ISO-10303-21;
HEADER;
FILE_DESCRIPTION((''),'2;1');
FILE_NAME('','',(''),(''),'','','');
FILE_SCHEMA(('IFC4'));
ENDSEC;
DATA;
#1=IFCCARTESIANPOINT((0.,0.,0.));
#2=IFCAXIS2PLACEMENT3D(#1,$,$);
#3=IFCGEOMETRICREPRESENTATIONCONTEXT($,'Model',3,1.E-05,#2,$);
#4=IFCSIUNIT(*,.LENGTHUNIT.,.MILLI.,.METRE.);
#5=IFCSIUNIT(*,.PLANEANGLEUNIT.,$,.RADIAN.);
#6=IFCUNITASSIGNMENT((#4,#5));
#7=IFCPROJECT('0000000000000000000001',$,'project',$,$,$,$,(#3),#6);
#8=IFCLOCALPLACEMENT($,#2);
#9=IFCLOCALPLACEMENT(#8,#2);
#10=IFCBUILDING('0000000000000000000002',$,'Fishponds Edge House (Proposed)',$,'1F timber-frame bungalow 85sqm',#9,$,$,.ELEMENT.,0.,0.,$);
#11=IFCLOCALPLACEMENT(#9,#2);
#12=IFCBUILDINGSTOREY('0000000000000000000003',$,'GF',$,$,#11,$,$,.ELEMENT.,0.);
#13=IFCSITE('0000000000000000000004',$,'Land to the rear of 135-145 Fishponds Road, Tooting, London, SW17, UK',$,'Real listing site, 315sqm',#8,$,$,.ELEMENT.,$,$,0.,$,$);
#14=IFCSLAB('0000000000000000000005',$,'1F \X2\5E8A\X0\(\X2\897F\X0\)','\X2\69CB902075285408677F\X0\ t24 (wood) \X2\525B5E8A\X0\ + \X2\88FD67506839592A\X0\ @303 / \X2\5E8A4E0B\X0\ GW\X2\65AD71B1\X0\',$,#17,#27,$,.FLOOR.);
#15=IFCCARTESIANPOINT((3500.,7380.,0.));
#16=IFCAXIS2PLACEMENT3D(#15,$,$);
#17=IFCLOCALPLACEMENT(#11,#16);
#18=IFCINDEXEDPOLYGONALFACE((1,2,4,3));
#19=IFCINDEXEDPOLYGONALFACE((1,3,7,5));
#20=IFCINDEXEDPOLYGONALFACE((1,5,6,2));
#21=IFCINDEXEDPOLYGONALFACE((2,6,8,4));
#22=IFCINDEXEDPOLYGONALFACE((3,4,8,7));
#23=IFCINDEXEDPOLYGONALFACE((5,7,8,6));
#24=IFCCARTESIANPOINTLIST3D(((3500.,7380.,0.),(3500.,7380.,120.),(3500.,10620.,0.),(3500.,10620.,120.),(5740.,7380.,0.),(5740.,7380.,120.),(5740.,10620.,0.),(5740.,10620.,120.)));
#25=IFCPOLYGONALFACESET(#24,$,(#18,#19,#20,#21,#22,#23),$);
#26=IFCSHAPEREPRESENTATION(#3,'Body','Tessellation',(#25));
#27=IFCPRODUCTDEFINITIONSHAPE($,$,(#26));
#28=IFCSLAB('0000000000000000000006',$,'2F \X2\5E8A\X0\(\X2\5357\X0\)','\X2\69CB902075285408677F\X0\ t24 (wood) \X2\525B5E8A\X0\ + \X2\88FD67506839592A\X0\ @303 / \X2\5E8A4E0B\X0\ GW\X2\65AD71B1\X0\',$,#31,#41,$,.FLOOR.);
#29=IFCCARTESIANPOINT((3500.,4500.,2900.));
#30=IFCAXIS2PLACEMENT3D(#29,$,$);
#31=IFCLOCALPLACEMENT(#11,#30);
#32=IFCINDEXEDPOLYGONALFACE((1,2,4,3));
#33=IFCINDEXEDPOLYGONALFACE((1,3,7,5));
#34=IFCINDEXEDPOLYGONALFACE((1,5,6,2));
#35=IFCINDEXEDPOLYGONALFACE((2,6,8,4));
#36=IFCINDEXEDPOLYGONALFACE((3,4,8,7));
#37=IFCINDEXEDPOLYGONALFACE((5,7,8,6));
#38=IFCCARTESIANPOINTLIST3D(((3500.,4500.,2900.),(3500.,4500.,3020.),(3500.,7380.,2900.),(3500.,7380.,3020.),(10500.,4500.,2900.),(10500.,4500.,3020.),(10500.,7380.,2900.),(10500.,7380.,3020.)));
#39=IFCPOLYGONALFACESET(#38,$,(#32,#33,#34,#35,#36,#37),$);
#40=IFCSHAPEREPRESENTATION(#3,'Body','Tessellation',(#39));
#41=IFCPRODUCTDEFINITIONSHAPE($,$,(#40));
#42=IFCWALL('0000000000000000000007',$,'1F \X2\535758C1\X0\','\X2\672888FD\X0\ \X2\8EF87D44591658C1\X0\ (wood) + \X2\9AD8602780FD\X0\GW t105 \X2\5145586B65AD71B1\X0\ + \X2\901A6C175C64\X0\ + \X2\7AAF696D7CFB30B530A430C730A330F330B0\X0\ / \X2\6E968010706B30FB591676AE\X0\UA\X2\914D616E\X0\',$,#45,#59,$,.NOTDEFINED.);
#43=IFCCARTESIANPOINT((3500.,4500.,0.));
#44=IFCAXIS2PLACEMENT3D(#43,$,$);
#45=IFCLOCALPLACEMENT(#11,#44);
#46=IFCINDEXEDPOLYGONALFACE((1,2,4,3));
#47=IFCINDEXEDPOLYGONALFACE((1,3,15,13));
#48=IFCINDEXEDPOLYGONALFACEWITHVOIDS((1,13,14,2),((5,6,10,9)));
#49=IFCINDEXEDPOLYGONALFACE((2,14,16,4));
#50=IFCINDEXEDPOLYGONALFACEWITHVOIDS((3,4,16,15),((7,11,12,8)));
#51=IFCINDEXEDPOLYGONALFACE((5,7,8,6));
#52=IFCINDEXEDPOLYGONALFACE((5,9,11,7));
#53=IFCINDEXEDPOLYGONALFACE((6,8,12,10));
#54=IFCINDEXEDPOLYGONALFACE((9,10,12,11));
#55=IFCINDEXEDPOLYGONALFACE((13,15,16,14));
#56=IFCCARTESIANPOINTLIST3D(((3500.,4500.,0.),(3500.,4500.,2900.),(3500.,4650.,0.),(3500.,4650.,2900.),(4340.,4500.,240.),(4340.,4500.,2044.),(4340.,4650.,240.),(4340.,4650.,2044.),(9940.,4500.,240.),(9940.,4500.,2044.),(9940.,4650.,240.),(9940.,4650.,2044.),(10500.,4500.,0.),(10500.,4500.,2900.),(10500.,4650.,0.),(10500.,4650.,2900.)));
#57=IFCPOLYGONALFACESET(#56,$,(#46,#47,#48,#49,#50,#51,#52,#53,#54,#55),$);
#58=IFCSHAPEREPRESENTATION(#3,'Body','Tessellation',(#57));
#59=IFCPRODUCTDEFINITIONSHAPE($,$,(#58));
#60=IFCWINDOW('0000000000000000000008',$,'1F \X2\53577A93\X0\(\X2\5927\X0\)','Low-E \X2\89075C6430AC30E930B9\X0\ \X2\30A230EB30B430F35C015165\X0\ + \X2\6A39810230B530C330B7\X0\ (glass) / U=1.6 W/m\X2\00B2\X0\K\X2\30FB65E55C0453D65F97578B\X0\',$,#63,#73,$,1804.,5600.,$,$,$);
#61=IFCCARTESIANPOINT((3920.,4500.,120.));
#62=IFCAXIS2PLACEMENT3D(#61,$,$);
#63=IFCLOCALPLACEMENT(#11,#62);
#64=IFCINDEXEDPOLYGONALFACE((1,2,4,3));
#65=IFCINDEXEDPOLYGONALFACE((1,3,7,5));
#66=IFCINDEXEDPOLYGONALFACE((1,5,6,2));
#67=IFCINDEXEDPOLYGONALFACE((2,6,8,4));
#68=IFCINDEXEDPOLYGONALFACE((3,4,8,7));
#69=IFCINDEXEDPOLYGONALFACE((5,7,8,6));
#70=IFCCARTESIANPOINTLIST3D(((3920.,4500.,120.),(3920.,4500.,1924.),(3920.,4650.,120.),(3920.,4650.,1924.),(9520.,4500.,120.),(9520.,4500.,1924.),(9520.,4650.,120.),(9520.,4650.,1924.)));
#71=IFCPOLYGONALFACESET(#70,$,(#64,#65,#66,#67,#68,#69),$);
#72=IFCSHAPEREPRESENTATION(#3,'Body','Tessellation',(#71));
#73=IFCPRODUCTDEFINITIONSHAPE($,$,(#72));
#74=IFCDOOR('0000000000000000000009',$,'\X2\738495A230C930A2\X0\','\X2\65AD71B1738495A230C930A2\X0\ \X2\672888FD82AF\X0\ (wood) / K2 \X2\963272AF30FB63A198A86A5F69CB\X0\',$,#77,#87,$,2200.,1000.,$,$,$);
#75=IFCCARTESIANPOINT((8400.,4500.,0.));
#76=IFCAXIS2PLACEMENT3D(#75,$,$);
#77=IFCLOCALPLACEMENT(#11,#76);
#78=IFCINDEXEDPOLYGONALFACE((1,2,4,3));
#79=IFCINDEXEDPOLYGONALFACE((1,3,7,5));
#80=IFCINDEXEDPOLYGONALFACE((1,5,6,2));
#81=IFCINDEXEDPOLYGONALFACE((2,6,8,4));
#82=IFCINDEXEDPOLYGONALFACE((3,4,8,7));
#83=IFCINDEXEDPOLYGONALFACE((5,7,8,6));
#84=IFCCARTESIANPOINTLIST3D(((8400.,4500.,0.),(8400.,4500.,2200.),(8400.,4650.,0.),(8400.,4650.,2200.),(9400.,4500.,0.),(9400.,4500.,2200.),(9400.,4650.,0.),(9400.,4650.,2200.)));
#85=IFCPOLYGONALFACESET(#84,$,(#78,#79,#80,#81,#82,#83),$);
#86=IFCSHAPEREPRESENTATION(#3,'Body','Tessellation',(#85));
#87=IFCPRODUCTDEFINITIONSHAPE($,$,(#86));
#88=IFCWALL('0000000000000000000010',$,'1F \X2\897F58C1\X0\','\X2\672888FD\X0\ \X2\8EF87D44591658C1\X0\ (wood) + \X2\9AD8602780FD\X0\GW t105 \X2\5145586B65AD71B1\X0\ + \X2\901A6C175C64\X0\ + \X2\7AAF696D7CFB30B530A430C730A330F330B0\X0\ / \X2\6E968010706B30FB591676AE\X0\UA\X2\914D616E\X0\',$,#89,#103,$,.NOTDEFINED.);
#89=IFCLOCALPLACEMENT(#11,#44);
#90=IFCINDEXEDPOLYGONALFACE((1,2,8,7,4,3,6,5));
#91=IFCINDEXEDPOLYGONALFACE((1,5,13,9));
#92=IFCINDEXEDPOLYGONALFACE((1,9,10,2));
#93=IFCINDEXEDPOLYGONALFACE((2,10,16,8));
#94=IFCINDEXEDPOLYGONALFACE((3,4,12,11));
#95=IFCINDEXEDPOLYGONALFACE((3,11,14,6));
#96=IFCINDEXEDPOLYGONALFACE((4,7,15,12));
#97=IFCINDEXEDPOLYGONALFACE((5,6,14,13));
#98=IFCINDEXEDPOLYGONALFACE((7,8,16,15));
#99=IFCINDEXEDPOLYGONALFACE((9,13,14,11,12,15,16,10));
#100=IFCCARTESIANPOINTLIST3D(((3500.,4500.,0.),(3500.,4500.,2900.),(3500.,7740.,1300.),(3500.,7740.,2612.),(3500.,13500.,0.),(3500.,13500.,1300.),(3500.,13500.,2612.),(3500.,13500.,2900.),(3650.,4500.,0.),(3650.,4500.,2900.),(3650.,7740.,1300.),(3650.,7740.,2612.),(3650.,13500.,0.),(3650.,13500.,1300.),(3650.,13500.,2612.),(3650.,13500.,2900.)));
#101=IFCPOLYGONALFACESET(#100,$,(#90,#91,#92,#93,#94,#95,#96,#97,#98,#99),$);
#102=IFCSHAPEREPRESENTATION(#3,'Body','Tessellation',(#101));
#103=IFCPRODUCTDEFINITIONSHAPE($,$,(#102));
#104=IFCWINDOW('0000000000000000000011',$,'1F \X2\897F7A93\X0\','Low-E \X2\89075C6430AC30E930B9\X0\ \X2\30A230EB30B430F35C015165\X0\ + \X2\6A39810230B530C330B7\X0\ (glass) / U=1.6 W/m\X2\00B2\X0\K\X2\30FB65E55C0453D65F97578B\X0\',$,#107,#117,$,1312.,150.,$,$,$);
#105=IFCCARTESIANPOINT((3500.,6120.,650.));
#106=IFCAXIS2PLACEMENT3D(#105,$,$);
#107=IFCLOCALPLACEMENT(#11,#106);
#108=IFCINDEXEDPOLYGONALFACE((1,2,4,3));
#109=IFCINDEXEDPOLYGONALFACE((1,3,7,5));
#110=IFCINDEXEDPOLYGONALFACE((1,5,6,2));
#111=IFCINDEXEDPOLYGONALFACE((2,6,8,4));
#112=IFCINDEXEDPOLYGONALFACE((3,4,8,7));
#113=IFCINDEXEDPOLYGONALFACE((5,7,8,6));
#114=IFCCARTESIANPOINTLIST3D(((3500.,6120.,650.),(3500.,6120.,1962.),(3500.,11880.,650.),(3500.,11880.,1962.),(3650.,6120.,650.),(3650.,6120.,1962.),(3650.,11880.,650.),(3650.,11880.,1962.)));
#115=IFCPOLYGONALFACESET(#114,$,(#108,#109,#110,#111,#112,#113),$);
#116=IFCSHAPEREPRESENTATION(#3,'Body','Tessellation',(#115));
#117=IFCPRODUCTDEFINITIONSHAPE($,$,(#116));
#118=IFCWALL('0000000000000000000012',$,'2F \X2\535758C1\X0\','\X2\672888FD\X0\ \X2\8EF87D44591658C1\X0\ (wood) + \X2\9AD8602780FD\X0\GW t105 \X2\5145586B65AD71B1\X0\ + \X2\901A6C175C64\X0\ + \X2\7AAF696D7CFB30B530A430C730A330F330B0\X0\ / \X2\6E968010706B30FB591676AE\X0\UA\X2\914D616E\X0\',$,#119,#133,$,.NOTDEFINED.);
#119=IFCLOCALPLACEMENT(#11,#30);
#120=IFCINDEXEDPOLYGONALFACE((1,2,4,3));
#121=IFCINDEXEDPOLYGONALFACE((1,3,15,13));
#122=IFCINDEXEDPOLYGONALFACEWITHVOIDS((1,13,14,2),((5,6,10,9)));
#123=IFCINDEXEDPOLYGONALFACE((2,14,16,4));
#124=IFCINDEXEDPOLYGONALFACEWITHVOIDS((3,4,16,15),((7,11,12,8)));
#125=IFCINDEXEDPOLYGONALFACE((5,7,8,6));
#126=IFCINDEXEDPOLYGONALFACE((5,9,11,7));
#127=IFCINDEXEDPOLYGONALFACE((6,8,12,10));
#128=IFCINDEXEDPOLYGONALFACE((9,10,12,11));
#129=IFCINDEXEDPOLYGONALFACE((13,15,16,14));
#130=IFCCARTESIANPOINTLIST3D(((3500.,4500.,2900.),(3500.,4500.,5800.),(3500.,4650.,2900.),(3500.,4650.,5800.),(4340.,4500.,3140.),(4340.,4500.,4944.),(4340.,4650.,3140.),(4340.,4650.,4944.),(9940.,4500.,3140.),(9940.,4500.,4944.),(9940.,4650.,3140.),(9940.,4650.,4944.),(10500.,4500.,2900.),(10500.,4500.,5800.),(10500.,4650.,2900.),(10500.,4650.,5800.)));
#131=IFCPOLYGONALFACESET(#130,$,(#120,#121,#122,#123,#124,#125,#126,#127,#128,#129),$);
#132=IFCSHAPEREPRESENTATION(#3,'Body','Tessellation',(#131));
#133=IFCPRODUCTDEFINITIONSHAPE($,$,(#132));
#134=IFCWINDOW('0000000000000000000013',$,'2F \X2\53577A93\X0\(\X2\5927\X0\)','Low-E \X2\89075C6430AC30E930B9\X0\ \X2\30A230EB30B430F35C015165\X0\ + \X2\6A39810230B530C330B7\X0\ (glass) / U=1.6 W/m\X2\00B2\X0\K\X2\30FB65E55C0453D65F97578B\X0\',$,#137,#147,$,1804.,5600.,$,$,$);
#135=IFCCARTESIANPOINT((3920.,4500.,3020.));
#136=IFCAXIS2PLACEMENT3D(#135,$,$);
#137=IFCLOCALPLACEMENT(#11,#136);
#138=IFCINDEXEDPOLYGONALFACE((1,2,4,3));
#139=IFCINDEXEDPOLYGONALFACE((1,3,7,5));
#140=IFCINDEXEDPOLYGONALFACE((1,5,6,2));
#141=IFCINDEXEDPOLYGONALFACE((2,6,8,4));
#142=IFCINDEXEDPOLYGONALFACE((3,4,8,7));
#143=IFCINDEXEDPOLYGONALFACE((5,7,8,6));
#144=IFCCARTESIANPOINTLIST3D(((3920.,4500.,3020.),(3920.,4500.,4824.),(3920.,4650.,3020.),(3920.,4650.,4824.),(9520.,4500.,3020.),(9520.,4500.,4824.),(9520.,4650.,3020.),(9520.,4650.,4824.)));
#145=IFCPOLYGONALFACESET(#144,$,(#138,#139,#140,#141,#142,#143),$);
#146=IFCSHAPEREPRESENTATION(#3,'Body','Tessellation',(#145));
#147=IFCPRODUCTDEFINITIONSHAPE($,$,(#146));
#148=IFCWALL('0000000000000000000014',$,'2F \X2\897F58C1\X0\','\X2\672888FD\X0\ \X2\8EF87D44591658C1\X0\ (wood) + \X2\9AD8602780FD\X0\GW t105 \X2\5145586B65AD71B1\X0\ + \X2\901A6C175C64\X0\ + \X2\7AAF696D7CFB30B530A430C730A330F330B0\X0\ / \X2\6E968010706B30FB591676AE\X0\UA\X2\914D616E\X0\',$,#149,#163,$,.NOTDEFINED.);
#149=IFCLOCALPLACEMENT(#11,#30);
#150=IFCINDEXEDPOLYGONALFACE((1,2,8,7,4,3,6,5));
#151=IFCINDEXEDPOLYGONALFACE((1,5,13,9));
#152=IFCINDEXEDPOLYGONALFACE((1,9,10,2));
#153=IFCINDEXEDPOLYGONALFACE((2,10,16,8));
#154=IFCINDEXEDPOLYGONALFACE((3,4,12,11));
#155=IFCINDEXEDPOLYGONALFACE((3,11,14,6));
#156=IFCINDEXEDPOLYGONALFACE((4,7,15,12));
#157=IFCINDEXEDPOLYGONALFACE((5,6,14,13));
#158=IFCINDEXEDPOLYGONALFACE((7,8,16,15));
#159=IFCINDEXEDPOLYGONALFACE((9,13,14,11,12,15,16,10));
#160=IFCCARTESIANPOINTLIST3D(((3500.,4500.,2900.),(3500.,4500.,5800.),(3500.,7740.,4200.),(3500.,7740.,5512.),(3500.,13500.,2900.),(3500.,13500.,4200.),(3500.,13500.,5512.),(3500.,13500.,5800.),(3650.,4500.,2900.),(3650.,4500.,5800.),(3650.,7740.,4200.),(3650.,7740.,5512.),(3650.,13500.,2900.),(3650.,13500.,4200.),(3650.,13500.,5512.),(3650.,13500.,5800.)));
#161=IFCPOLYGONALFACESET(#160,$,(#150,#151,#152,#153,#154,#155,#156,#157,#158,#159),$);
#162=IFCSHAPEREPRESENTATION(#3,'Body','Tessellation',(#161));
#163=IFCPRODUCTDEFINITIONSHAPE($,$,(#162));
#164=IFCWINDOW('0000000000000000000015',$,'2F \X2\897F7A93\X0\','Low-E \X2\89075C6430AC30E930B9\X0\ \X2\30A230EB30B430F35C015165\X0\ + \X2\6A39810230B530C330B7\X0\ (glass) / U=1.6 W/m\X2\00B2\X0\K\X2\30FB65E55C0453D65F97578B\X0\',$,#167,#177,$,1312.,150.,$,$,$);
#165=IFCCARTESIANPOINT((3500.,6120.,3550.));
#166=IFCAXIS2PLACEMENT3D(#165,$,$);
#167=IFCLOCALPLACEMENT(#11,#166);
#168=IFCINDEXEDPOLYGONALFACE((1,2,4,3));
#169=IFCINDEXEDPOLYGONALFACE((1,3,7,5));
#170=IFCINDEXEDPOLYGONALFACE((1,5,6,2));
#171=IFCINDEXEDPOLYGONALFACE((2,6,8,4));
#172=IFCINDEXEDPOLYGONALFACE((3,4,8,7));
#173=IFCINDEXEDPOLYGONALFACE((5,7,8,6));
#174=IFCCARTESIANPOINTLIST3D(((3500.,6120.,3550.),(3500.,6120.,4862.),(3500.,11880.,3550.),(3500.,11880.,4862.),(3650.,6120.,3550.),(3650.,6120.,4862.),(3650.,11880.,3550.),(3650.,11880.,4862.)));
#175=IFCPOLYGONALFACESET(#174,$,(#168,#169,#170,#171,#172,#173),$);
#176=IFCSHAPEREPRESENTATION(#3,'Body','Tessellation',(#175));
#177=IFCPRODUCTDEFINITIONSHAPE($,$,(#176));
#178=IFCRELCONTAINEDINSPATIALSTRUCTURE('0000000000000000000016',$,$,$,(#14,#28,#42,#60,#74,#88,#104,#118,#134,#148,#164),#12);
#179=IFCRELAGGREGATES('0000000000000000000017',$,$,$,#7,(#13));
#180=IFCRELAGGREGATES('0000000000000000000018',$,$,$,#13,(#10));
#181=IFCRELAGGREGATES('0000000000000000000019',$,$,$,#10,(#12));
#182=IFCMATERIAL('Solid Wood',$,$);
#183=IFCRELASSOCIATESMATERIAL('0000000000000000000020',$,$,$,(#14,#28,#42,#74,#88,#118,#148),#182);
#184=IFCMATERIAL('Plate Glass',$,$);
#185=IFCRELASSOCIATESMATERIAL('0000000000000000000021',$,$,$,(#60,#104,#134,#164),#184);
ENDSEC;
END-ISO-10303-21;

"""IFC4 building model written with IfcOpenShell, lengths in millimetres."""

from ifc_helpers import new_model, si_unit, frame, frame_2d, origin, place, context, project, spatial, rectangle, extrude, material, element, fill, save


model = new_model("IFC4")

# Units and contexts
model_context = context("Model", 3, precision=1e-05, world=origin())
ifc_project = project(units=[si_unit("LENGTHUNIT", "METRE", prefix="MILLI"), si_unit("PLANEANGLEUNIT", "RADIAN")], contexts=[model_context])

# Site, building, storey
site_placement = place(None, origin())
site = spatial("IfcSite", under=ifc_project, at=site_placement, Name="Land to the rear of 135-145 Fishponds Road, Tooting, London, SW17, UK", ObjectType="Real listing site, 315sqm", CompositionType="ELEMENT", RefElevation=0.0)
building_placement = place(site_placement, origin())
building = spatial("IfcBuilding", under=site, at=building_placement, Name="Fishponds Edge House (Proposed)", ObjectType="1F timber-frame bungalow 85sqm", CompositionType="ELEMENT", ElevationOfRefHeight=0.0, ElevationOfTerrain=0.0)
storey_placement = place(building_placement, origin())
storey = spatial("IfcBuildingStorey", under=building, at=storey_placement, Name="GF", CompositionType="ELEMENT", Elevation=0.0)

# Slabs
ifc_material_1 = material(Name="Solid Wood")
slab_1_placement = place(storey_placement, frame((3500.0, 7380.0, 0.0)))
element("IfcSlab", 1, at=slab_1_placement, inside=storey, material=ifc_material_1, Name="1F 床(西)", Description="構造用合板 t24 (wood) 剛床 + 製材根太 @303 / 床下 GW断熱", PredefinedType="FLOOR", context=model_context, shape_type="SweptSolid", body=[
    extrude(rectangle(XDim=2240.0, YDim=3240.0, at=frame_2d((1120.0, 1620.0))), frame((3500.0, 7380.0, 0.0)), (0.0, 0.0, 1.0), 120.0),
])
slab_2_placement = place(storey_placement, frame((3500.0, 4500.0, 2900.0)))
element("IfcSlab", 2, at=slab_2_placement, inside=storey, material=ifc_material_1, Name="2F 床(南)", Description="構造用合板 t24 (wood) 剛床 + 製材根太 @303 / 床下 GW断熱", PredefinedType="FLOOR", context=model_context, shape_type="SweptSolid", body=[
    extrude(rectangle(XDim=7000.0, YDim=2880.0, at=frame_2d((3500.0, 1440.0))), frame((3500.0, 4500.0, 2900.0)), (0.0, 0.0, 1.0), 120.0),
])

# Wall, openings, window, door
wall_1_placement = place(storey_placement, frame((3500.0, 4500.0, 0.0)))
wall_1 = element("IfcWall", 3, at=wall_1_placement, inside=storey, material=ifc_material_1, Name="1F 南壁", Description="木製 軸組外壁 (wood) + 高性能GW t105 充填断熱 + 通気層 + 窯業系サイディング / 準耐火・外皮UA配慮", PredefinedType="NOTDEFINED", context=model_context, shape_type="SweptSolid", body=[
    extrude(rectangle(XDim=7000.0, YDim=150.0, at=frame_2d((3500.0, 75.0))), frame((3500.0, 4500.0, 0.0)), (0.0, 0.0, 1.0), 2900.0),
])
opening_1_placement = place(storey_placement, frame((3920.0, 4500.0, 120.0)))
opening_1 = element("IfcOpeningElement", 4, at=opening_1_placement, cuts=wall_1, PredefinedType="NOTDEFINED", context=model_context, shape_type="SweptSolid", body=[
    extrude(rectangle(XDim=5600.0, YDim=150.0, at=frame_2d((2800.0, 75.0))), frame((3920.0, 4500.0, 120.0)), (0.0, 0.0, 1.0), 1804.0),
])
opening_2_placement = place(storey_placement, frame((8400.0, 4500.0, 0.0)))
opening_2 = element("IfcOpeningElement", 5, at=opening_2_placement, cuts=wall_1, PredefinedType="NOTDEFINED", context=model_context, shape_type="SweptSolid", body=[
    extrude(rectangle(XDim=1000.0, YDim=150.0, at=frame_2d((500.0, 75.0))), frame((8400.0, 4500.0, 0.0)), (0.0, 0.0, 1.0), 2200.0),
])
ifc_material_2 = material(Name="Plate Glass")
window_1_placement = place(storey_placement, frame((3920.0, 4500.0, 120.0)))
window_1 = element("IfcWindow", 6, at=window_1_placement, inside=storey, material=ifc_material_2, Name="1F 南窓(大)", Description="Low-E 複層ガラス アルゴン封入 + 樹脂サッシ (glass) / U=1.6 W/m²K・日射取得型", OverallHeight=1804.0, OverallWidth=5600.0, context=model_context, shape_type="SweptSolid", body=[
    extrude(rectangle(XDim=5600.0, YDim=150.0, at=frame_2d((2800.0, 75.0))), frame((3920.0, 4500.0, 120.0)), (0.0, 0.0, 1.0), 1804.0),
])
fill(opening_1, window_1)
door_placement = place(storey_placement, frame((8400.0, 4500.0, 0.0)))
door = element("IfcDoor", 7, at=door_placement, inside=storey, material=ifc_material_1, Name="玄関ドア", Description="断熱玄関ドア 木製芯 (wood) / K2 防犯・採風機構", OverallHeight=2200.0, OverallWidth=1000.0, context=model_context, shape_type="SweptSolid", body=[
    extrude(rectangle(XDim=1000.0, YDim=150.0, at=frame_2d((500.0, 75.0))), frame((8400.0, 4500.0, 0.0)), (0.0, 0.0, 1.0), 2200.0),
])
fill(opening_2, door)

# Walls, openings, windows
wall_2_placement = place(storey_placement, frame((3500.0, 4500.0, 0.0)))
wall_2 = element("IfcWall", 8, at=wall_2_placement, inside=storey, material=ifc_material_1, Name="1F 西壁", Description="木製 軸組外壁 (wood) + 高性能GW t105 充填断熱 + 通気層 + 窯業系サイディング / 準耐火・外皮UA配慮", PredefinedType="NOTDEFINED", context=model_context, shape_type="SweptSolid", body=[
    extrude(rectangle(XDim=150.0, YDim=9000.0, at=frame_2d((75.0, 4500.0))), frame((3500.0, 4500.0, 0.0)), (0.0, 0.0, 1.0), 2900.0),
])
opening_3_placement = place(storey_placement, frame((3500.0, 6120.0, 650.0)))
opening_3 = element("IfcOpeningElement", 9, at=opening_3_placement, cuts=wall_2, PredefinedType="NOTDEFINED", context=model_context, shape_type="SweptSolid", body=[
    extrude(rectangle(XDim=150.0, YDim=5760.0, at=frame_2d((75.0, 2880.0))), frame((3500.0, 6120.0, 650.0)), (0.0, 0.0, 1.0), 1312.0),
])
window_2_placement = place(storey_placement, frame((3500.0, 6120.0, 650.0)))
window_2 = element("IfcWindow", 10, at=window_2_placement, inside=storey, material=ifc_material_2, Name="1F 西窓", Description="Low-E 複層ガラス アルゴン封入 + 樹脂サッシ (glass) / U=1.6 W/m²K・日射取得型", OverallHeight=1312.0, OverallWidth=150.0, context=model_context, shape_type="SweptSolid", body=[
    extrude(rectangle(XDim=150.0, YDim=5760.0, at=frame_2d((75.0, 2880.0))), frame((3500.0, 6120.0, 650.0)), (0.0, 0.0, 1.0), 1312.0),
])
fill(opening_3, window_2)
wall_3_placement = place(storey_placement, frame((3500.0, 4500.0, 2900.0)))
wall_3 = element("IfcWall", 11, at=wall_3_placement, inside=storey, material=ifc_material_1, Name="2F 南壁", Description="木製 軸組外壁 (wood) + 高性能GW t105 充填断熱 + 通気層 + 窯業系サイディング / 準耐火・外皮UA配慮", PredefinedType="NOTDEFINED", context=model_context, shape_type="SweptSolid", body=[
    extrude(rectangle(XDim=7000.0, YDim=150.0, at=frame_2d((3500.0, 75.0))), frame((3500.0, 4500.0, 2900.0)), (0.0, 0.0, 1.0), 2900.0),
])
opening_4_placement = place(storey_placement, frame((3920.0, 4500.0, 3020.0)))
opening_4 = element("IfcOpeningElement", 12, at=opening_4_placement, cuts=wall_3, PredefinedType="NOTDEFINED", context=model_context, shape_type="SweptSolid", body=[
    extrude(rectangle(XDim=5600.0, YDim=150.0, at=frame_2d((2800.0, 75.0))), frame((3920.0, 4500.0, 3020.0)), (0.0, 0.0, 1.0), 1804.0),
])
window_3_placement = place(storey_placement, frame((3920.0, 4500.0, 3020.0)))
window_3 = element("IfcWindow", 13, at=window_3_placement, inside=storey, material=ifc_material_2, Name="2F 南窓(大)", Description="Low-E 複層ガラス アルゴン封入 + 樹脂サッシ (glass) / U=1.6 W/m²K・日射取得型", OverallHeight=1804.0, OverallWidth=5600.0, context=model_context, shape_type="SweptSolid", body=[
    extrude(rectangle(XDim=5600.0, YDim=150.0, at=frame_2d((2800.0, 75.0))), frame((3920.0, 4500.0, 3020.0)), (0.0, 0.0, 1.0), 1804.0),
])
fill(opening_4, window_3)
wall_4_placement = place(storey_placement, frame((3500.0, 4500.0, 2900.0)))
wall_4 = element("IfcWall", 14, at=wall_4_placement, inside=storey, material=ifc_material_1, Name="2F 西壁", Description="木製 軸組外壁 (wood) + 高性能GW t105 充填断熱 + 通気層 + 窯業系サイディング / 準耐火・外皮UA配慮", PredefinedType="NOTDEFINED", context=model_context, shape_type="SweptSolid", body=[
    extrude(rectangle(XDim=150.0, YDim=9000.0, at=frame_2d((75.0, 4500.0))), frame((3500.0, 4500.0, 2900.0)), (0.0, 0.0, 1.0), 2900.0),
])
opening_5_placement = place(storey_placement, frame((3500.0, 6120.0, 3550.0)))
opening_5 = element("IfcOpeningElement", 15, at=opening_5_placement, cuts=wall_4, PredefinedType="NOTDEFINED", context=model_context, shape_type="SweptSolid", body=[
    extrude(rectangle(XDim=150.0, YDim=5760.0, at=frame_2d((75.0, 2880.0))), frame((3500.0, 6120.0, 3550.0)), (0.0, 0.0, 1.0), 1312.0),
])
window_4_placement = place(storey_placement, frame((3500.0, 6120.0, 3550.0)))
window_4 = element("IfcWindow", 16, at=window_4_placement, inside=storey, material=ifc_material_2, Name="2F 西窓", Description="Low-E 複層ガラス アルゴン封入 + 樹脂サッシ (glass) / U=1.6 W/m²K・日射取得型", OverallHeight=1312.0, OverallWidth=150.0, context=model_context, shape_type="SweptSolid", body=[
    extrude(rectangle(XDim=150.0, YDim=5760.0, at=frame_2d((75.0, 2880.0))), frame((3500.0, 6120.0, 3550.0)), (0.0, 0.0, 1.0), 1312.0),
])
fill(opening_5, window_4)

save(model, "model.ifc")
